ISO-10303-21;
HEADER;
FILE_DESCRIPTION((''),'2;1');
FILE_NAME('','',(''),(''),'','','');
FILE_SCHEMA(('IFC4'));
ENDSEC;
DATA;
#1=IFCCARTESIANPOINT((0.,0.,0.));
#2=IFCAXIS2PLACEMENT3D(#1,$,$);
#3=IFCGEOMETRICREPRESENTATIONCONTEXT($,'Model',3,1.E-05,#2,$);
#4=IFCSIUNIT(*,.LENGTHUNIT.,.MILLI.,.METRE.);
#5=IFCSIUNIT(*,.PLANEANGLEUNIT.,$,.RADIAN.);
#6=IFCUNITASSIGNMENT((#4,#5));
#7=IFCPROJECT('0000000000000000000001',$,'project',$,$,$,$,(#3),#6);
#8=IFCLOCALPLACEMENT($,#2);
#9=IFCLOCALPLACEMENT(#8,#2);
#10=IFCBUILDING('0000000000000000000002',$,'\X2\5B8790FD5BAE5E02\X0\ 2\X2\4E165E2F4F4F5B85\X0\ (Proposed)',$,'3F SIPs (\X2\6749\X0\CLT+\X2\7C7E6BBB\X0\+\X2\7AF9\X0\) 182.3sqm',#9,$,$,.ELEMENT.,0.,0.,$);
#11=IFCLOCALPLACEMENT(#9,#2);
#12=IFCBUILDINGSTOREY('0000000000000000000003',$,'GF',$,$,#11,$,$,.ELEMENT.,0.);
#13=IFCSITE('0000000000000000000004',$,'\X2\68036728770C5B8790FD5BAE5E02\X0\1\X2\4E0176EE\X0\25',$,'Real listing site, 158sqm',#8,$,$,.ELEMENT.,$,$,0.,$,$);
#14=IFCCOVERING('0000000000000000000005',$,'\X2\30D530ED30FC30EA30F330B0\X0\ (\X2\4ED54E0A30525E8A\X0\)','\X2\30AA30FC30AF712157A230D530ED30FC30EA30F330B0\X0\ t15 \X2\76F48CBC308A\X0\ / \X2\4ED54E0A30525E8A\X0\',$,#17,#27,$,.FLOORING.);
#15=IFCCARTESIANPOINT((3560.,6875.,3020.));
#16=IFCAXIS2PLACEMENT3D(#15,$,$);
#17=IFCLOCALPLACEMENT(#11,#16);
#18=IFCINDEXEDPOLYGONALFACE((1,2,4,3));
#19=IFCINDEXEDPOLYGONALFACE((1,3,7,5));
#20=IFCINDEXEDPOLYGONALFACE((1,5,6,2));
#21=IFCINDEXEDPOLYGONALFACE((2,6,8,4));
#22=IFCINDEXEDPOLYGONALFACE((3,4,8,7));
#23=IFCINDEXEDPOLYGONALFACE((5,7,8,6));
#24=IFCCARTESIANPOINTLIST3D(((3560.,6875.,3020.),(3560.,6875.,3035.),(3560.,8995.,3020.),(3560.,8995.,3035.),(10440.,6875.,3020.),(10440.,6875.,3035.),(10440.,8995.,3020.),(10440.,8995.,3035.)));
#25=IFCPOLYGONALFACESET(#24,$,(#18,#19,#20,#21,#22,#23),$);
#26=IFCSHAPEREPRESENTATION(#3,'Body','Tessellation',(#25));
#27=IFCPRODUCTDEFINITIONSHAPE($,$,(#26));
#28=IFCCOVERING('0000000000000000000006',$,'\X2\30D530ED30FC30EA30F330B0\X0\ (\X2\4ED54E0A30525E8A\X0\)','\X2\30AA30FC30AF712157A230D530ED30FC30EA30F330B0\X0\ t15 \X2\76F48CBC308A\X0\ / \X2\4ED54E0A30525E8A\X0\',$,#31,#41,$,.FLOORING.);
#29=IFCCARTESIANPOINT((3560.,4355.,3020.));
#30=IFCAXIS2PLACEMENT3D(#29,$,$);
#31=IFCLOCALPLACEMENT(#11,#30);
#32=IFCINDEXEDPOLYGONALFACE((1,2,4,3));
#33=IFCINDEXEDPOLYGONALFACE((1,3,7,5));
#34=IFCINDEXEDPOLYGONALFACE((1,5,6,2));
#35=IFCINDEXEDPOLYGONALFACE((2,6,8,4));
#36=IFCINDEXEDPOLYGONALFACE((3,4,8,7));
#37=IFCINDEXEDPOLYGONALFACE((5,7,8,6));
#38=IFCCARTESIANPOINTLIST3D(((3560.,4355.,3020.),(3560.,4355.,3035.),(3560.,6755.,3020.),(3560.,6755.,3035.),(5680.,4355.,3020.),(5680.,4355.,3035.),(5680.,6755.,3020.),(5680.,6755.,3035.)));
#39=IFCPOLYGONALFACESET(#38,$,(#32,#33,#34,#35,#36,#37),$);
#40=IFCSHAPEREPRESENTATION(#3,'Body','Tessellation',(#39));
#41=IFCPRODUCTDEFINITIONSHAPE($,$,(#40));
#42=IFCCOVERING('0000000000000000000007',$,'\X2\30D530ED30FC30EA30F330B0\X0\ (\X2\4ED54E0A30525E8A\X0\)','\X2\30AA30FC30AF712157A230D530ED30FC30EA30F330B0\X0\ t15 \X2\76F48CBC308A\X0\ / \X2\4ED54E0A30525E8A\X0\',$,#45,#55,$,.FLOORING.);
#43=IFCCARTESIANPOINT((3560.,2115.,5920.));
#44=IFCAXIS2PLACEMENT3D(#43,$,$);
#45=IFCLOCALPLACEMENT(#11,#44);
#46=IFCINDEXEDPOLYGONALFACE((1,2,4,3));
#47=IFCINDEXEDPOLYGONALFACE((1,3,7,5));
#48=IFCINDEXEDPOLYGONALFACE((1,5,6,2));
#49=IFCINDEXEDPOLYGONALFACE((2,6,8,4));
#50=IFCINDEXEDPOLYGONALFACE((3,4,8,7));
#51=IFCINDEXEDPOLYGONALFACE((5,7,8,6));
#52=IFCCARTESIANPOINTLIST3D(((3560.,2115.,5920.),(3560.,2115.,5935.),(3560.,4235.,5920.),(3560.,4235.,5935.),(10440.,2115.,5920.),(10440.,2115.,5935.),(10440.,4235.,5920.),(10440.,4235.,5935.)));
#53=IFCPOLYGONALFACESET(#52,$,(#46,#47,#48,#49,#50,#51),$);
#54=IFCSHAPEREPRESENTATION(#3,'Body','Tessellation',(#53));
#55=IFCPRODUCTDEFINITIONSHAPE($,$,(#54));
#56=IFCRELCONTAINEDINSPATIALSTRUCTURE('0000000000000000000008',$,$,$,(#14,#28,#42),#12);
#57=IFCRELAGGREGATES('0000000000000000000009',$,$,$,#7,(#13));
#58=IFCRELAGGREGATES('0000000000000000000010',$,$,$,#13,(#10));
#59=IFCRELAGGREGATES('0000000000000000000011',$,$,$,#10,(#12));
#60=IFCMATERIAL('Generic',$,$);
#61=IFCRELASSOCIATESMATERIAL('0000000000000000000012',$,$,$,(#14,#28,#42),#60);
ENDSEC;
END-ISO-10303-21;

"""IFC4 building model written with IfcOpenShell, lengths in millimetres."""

from ifc_helpers import new_model, si_unit, frame, frame_2d, origin, place, context, project, spatial, rectangle, extrude, material, element, save


model = new_model("IFC4")

# Units and contexts
model_context = context("Model", 3, precision=1e-05, world=origin())
ifc_project = project(units=[si_unit("LENGTHUNIT", "METRE", prefix="MILLI"), si_unit("PLANEANGLEUNIT", "RADIAN")], contexts=[model_context])

# Site, building, storey
site_placement = place(None, origin())
site = spatial("IfcSite", under=ifc_project, at=site_placement, Name="栃木県宇都宮市1丁目25", ObjectType="Real listing site, 158sqm", CompositionType="ELEMENT", RefElevation=0.0)
building_placement = place(site_placement, origin())
building = spatial("IfcBuilding", under=site, at=building_placement, Name="宇都宮市 2世帯住宅 (Proposed)", ObjectType="3F SIPs (杉CLT+籾殻+竹) 182.3sqm", CompositionType="ELEMENT", ElevationOfRefHeight=0.0, ElevationOfTerrain=0.0)
storey_placement = place(building_placement, origin())
storey = spatial("IfcBuildingStorey", under=building, at=storey_placement, Name="GF", CompositionType="ELEMENT", Elevation=0.0)

# Shared definitions
ifc_material_1 = material(Name="Generic")

# Coverings
covering_1_placement = place(storey_placement, frame((3560.0, 6875.0, 3020.0)))
element("IfcCovering", 1, at=covering_1_placement, inside=storey, material=ifc_material_1, Name="フローリング (仕上げ床)", Description="オーク無垢フローリング t15 直貼り / 仕上げ床", PredefinedType="FLOORING", context=model_context, shape_type="SweptSolid", body=[
    extrude(rectangle(XDim=6880.0, YDim=2120.0, at=frame_2d((3440.0, 1060.0))), frame((3560.0, 6875.0, 3020.0)), (0.0, 0.0, 1.0), 15.0),
])
covering_2_placement = place(storey_placement, frame((3560.0, 4355.0, 3020.0)))
element("IfcCovering", 2, at=covering_2_placement, inside=storey, material=ifc_material_1, Name="フローリング (仕上げ床)", Description="オーク無垢フローリング t15 直貼り / 仕上げ床", PredefinedType="FLOORING", context=model_context, shape_type="SweptSolid", body=[
    extrude(rectangle(XDim=2120.0, YDim=2400.0, at=frame_2d((1060.0, 1200.0))), frame((3560.0, 4355.0, 3020.0)), (0.0, 0.0, 1.0), 15.0),
])
covering_3_placement = place(storey_placement, frame((3560.0, 2115.0, 5920.0)))
element("IfcCovering", 3, at=covering_3_placement, inside=storey, material=ifc_material_1, Name="フローリング (仕上げ床)", Description="オーク無垢フローリング t15 直貼り / 仕上げ床", PredefinedType="FLOORING", context=model_context, shape_type="SweptSolid", body=[
    extrude(rectangle(XDim=6880.0, YDim=2120.0, at=frame_2d((3440.0, 1060.0))), frame((3560.0, 2115.0, 5920.0)), (0.0, 0.0, 1.0), 15.0),
])

save(model, "model.ifc")
